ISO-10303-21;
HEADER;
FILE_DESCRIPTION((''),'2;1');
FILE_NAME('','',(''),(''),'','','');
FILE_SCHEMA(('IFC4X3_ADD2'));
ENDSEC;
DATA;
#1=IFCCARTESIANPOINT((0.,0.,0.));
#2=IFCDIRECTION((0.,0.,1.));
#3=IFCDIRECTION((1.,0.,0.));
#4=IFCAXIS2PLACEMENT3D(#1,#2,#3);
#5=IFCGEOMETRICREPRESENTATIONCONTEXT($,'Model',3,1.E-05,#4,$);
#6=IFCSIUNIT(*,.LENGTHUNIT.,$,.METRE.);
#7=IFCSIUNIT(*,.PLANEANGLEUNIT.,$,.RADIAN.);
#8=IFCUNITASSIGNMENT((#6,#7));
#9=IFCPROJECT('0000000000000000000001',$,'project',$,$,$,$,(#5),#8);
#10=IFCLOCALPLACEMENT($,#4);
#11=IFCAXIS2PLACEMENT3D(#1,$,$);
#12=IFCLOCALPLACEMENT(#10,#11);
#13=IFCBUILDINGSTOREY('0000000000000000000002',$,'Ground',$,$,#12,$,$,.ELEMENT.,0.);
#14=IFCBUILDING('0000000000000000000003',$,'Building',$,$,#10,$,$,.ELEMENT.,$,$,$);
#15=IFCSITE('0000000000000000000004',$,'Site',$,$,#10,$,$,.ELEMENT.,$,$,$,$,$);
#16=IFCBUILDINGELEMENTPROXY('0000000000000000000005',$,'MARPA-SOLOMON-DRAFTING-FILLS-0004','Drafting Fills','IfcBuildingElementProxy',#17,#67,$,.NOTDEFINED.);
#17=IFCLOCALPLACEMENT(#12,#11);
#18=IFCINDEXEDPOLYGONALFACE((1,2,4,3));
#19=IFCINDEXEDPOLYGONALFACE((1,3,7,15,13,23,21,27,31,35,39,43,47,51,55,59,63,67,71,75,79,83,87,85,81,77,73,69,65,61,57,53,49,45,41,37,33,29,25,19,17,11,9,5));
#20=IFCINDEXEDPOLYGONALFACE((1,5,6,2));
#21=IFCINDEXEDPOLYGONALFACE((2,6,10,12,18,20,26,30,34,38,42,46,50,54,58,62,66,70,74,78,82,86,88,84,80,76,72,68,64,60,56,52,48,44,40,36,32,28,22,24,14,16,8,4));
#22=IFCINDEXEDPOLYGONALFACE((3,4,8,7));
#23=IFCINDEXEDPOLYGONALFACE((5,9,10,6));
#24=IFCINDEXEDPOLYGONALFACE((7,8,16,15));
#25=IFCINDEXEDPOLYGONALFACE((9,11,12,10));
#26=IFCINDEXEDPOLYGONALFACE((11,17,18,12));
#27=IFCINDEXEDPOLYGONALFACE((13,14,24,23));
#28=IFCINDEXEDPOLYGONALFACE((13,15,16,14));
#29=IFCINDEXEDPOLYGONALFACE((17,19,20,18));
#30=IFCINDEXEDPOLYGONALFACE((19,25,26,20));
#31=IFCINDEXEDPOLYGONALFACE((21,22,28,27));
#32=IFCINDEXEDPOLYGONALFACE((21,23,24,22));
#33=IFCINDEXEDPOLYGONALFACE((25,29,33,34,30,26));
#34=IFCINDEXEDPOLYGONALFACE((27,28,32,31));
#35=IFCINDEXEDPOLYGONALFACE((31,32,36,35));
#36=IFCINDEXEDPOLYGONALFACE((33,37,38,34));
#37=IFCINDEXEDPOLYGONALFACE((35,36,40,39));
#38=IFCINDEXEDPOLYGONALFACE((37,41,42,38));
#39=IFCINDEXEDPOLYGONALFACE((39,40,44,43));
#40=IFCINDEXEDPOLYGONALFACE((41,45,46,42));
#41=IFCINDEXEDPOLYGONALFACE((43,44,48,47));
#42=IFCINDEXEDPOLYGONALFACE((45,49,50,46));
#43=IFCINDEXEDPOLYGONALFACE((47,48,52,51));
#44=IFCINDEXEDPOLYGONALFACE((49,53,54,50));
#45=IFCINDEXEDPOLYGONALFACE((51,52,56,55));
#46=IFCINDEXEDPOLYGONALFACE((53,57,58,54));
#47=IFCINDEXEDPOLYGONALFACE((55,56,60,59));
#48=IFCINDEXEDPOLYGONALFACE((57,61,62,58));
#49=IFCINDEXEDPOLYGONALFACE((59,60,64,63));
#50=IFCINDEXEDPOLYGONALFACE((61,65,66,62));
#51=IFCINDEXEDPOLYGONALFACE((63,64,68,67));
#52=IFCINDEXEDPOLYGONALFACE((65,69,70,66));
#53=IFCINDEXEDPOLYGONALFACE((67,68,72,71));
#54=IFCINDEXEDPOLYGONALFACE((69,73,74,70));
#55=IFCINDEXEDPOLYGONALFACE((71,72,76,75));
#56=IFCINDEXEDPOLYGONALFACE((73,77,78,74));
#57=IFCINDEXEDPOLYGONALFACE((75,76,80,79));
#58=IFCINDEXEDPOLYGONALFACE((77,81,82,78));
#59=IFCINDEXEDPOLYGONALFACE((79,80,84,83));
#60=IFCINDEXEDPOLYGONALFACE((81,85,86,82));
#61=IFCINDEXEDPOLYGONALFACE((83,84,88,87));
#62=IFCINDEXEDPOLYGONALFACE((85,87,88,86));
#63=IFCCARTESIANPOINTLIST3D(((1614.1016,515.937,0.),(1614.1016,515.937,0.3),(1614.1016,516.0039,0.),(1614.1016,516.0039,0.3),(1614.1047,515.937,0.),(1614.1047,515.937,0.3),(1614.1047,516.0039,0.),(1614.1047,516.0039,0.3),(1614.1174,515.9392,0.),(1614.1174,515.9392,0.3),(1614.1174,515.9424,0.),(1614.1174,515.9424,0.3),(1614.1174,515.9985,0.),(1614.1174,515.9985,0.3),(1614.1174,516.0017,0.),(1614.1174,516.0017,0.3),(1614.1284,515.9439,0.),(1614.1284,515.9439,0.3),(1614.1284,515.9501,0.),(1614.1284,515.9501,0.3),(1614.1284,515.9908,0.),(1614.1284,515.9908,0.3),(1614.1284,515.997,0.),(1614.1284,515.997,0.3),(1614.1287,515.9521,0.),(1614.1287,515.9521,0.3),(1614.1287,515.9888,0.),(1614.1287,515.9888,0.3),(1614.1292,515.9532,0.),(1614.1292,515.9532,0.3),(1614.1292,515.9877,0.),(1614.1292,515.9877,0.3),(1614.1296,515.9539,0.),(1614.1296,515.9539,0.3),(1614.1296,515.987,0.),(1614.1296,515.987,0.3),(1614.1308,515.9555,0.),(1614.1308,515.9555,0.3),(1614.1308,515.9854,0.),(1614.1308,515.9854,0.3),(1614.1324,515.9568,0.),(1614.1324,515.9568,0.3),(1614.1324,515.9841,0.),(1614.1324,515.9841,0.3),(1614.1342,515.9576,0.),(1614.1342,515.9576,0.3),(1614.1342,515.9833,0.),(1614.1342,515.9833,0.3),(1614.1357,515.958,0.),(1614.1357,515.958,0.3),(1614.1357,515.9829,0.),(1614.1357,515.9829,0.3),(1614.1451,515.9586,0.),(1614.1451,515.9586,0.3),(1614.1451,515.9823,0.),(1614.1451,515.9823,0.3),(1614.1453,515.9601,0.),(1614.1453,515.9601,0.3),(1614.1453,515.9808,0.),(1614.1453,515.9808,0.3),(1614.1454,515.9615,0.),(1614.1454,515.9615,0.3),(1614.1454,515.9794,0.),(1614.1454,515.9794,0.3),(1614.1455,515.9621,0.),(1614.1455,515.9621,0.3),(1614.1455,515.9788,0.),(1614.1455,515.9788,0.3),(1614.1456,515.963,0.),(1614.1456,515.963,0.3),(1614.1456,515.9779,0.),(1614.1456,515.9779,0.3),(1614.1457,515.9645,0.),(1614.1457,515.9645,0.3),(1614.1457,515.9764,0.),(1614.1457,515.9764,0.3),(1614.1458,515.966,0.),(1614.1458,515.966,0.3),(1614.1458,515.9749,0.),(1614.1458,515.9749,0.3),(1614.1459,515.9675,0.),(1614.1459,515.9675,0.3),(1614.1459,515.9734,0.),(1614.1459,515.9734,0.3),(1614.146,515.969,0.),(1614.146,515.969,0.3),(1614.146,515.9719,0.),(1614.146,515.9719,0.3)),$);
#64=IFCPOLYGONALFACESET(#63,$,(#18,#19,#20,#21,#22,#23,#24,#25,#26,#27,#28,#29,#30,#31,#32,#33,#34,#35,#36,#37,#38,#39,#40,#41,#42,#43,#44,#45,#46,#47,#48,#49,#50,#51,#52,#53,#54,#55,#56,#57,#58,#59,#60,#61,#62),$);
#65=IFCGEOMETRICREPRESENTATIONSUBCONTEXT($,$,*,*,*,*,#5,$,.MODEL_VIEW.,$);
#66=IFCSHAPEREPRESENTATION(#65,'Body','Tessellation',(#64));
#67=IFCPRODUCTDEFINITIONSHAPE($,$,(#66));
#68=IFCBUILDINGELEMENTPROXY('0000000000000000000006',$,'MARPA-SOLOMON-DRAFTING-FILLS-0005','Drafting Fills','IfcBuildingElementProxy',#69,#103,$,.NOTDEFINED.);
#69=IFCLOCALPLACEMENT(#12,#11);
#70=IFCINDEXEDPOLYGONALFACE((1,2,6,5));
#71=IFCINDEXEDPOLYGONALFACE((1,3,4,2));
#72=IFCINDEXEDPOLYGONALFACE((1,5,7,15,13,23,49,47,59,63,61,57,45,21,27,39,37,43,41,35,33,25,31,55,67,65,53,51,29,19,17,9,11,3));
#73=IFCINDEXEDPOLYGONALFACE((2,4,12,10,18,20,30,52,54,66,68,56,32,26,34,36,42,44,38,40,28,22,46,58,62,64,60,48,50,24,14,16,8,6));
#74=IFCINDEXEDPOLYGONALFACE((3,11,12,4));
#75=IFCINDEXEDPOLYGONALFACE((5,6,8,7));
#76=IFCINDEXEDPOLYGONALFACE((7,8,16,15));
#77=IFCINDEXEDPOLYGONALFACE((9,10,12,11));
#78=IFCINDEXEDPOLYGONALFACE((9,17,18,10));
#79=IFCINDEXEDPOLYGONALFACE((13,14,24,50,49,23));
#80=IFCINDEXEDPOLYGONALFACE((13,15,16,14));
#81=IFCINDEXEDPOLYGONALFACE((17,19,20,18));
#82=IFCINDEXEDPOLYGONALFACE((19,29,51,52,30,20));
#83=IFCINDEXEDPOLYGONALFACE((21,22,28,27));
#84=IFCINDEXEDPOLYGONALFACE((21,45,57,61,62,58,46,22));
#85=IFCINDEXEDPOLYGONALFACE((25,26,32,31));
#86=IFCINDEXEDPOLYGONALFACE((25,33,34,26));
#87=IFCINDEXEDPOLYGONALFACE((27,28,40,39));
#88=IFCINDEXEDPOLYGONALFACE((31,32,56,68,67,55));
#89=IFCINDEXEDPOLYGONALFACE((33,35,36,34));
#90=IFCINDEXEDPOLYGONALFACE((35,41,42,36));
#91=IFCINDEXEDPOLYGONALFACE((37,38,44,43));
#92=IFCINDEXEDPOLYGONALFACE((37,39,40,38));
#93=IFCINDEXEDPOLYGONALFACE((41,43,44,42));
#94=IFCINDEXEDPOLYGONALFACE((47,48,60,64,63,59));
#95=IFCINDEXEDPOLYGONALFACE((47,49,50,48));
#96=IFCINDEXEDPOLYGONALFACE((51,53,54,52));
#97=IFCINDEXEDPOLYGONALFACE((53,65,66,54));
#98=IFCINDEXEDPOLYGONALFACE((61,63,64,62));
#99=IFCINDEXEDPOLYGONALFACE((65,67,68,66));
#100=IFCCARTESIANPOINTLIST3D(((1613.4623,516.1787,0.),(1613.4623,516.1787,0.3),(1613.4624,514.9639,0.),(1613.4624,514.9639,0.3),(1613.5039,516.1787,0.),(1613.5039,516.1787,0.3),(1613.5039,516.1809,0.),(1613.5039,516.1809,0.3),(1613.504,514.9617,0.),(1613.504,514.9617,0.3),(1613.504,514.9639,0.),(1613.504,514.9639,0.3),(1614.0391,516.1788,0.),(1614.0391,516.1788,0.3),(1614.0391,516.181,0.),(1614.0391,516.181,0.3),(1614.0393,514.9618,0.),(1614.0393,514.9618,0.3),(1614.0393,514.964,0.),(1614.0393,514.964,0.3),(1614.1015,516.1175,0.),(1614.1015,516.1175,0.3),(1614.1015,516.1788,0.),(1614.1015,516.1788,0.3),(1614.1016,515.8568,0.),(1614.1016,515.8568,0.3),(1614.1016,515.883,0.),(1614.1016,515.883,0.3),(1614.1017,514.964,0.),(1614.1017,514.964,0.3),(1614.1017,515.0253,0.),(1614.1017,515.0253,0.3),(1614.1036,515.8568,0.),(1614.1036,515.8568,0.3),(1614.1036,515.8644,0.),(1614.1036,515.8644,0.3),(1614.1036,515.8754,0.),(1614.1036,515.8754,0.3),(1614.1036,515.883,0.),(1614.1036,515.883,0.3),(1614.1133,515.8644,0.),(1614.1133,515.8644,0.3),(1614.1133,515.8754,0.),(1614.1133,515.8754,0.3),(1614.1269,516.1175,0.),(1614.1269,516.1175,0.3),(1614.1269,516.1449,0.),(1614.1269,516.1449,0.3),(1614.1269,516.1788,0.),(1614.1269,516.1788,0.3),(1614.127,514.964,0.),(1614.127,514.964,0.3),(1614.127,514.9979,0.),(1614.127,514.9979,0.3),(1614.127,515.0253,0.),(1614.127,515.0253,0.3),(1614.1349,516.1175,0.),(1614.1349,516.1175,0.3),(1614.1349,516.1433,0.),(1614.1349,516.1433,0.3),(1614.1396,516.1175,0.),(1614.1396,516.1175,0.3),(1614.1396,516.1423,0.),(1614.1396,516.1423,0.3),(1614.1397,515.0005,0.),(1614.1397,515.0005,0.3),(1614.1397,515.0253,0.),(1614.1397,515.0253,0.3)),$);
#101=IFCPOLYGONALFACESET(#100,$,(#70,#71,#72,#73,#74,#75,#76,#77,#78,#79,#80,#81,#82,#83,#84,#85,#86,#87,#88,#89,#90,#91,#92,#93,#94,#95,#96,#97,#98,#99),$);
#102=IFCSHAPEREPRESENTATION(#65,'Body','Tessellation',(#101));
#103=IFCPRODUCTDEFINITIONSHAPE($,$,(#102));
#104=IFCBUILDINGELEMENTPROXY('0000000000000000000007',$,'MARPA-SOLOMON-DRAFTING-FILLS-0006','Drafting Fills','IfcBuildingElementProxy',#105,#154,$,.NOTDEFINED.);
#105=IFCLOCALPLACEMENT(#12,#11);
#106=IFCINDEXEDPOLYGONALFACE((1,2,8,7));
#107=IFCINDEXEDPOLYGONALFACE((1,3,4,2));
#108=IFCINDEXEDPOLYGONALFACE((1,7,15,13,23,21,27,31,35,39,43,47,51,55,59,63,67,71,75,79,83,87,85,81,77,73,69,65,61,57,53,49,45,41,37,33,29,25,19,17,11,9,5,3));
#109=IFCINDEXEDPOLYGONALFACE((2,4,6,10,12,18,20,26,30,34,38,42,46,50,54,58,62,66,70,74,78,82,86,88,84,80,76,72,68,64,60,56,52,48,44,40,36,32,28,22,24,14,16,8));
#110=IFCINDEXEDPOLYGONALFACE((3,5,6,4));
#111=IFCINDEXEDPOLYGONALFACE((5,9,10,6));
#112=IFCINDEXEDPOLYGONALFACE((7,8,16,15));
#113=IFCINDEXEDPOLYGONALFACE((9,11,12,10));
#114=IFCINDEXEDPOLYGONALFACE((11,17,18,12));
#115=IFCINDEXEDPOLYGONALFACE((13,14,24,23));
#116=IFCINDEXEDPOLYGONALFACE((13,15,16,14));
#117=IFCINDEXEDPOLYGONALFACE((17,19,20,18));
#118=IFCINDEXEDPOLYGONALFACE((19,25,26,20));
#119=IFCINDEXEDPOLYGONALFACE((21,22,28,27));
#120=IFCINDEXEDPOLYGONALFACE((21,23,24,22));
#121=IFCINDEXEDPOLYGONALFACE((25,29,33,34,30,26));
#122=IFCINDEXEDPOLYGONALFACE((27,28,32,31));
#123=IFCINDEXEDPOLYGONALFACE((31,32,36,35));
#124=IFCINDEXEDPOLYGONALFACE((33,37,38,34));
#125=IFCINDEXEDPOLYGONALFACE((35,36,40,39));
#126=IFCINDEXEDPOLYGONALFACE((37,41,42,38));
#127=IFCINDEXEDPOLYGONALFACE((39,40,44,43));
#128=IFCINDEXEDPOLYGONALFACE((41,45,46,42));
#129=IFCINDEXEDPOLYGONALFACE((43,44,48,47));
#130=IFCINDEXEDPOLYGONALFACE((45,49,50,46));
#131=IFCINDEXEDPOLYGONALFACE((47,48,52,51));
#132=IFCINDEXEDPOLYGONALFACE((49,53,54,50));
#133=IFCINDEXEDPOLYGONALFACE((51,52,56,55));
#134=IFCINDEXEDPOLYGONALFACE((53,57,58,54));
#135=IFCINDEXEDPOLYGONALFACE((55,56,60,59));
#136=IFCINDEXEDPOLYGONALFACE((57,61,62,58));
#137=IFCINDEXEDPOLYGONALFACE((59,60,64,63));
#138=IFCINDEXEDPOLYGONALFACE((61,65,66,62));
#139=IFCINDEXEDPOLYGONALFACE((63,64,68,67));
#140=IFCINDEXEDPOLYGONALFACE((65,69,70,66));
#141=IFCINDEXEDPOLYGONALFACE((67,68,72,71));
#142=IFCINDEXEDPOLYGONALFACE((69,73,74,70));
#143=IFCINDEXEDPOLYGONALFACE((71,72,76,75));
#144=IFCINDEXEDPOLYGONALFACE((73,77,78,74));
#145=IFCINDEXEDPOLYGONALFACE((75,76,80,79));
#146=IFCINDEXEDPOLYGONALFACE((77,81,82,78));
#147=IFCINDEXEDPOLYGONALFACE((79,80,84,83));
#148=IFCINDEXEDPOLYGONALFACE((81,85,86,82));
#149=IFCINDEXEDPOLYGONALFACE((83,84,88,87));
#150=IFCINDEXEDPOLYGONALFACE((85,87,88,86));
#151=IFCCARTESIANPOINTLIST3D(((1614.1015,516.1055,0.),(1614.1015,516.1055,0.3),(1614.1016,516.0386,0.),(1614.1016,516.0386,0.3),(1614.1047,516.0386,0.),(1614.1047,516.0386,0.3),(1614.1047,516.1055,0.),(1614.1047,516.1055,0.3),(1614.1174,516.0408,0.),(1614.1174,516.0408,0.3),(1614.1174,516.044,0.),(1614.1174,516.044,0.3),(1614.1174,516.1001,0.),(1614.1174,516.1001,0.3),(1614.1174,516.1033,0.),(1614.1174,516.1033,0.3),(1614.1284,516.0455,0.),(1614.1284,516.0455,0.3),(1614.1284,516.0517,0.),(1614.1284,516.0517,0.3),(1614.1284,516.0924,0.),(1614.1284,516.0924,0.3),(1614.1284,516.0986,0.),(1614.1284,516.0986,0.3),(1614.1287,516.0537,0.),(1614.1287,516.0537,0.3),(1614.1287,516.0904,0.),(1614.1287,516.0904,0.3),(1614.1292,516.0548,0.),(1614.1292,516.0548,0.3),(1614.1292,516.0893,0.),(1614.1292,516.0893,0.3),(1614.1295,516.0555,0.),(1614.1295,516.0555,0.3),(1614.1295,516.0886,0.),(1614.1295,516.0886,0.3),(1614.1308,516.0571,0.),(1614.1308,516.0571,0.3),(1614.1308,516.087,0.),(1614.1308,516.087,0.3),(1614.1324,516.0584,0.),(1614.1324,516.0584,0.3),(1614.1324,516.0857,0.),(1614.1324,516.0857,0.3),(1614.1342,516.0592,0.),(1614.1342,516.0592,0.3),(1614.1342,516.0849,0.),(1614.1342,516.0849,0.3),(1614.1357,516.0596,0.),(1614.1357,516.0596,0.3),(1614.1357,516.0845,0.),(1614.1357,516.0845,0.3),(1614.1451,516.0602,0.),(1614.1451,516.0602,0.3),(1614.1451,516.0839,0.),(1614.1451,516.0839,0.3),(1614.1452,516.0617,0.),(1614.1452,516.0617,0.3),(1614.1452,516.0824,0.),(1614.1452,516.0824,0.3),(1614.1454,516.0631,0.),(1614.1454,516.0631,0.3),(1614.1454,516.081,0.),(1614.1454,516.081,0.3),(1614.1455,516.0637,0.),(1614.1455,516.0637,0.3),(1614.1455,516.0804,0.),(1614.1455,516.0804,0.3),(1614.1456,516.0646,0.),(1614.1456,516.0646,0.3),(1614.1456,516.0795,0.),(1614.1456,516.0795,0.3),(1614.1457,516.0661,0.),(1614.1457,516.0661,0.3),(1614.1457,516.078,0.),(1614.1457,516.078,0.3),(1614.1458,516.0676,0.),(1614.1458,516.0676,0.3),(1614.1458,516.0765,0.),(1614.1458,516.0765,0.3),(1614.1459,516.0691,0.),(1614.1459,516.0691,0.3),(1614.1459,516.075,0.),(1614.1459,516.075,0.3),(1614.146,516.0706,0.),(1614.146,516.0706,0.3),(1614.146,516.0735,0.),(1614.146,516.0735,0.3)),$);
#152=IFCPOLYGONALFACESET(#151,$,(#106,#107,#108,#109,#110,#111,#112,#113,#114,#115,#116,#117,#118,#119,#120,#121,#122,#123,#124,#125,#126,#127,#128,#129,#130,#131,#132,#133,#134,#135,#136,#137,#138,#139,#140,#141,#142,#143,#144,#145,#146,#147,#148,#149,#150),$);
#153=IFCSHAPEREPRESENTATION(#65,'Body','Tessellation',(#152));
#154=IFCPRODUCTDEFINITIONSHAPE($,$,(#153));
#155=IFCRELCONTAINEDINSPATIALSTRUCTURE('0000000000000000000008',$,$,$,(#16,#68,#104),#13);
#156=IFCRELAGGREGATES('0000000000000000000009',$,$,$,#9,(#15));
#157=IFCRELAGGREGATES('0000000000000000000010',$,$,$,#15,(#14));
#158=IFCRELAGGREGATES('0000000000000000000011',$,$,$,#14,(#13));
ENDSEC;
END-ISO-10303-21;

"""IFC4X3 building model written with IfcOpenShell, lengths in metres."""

from ifc_helpers import new_model, si_unit, frame, origin, origin_with_axes, place, context, subcontext, project, spatial, polyline, outline, extrude, element, save


model = new_model("IFC4X3")

# Units and contexts
model_context = context("Model", 3, precision=1e-05, world=origin_with_axes())
sub_context = subcontext(model_context, None, None, "MODEL_VIEW")
ifc_project = project(units=[si_unit("LENGTHUNIT", "METRE"), si_unit("PLANEANGLEUNIT", "RADIAN")], contexts=[model_context])

# Site, building, storey
placement = place(None, origin_with_axes())
site = spatial("IfcSite", under=ifc_project, at=placement, Name="Site", CompositionType="ELEMENT")
building = spatial("IfcBuilding", under=site, at=placement, Name="Building", CompositionType="ELEMENT")
storey_placement = place(placement, origin())
storey = spatial("IfcBuildingStorey", under=building, at=storey_placement, Name="Ground", CompositionType="ELEMENT", Elevation=0.0)

# Building element proxies
proxy_1_placement = place(placement, frame((1614.1016, 515.937, 0.0)))
element("IfcBuildingElementProxy", 1, at=proxy_1_placement, inside=storey, Name="MARPA-SOLOMON-DRAFTING-FILLS-0004", Description="Drafting Fills", ObjectType="IfcBuildingElementProxy", PredefinedType="NOTDEFINED", context=sub_context, shape_type="SweptSolid", body=[
    extrude(outline(polyline([(0.0159, 0.0022), (0.0159, 0.0054), (0.0268, 0.007), (0.0268, 0.0131), (0.0272, 0.0151), (0.0277, 0.0162), (0.028, 0.017), (0.0292, 0.0186), (0.0308, 0.0198), (0.0326, 0.0207), (0.0342, 0.021), (0.0435, 0.0216), (0.0437, 0.0231), (0.0439, 0.0246), (0.0439, 0.0251), (0.044, 0.0261), (0.0441, 0.0275), (0.0443, 0.029), (0.0443, 0.0305), (0.0445, 0.032), (0.0445, 0.035), (0.0443, 0.0365), (0.0442, 0.0379), (0.0441, 0.0394), (0.044, 0.0409), (0.0439, 0.0419), (0.0439, 0.0424), (0.0437, 0.0439), (0.0435, 0.0453), (0.0342, 0.046), (0.0326, 0.0463), (0.0308, 0.0471), (0.0292, 0.0484), (0.028, 0.05), (0.0277, 0.0507), (0.0272, 0.0519), (0.0268, 0.0538), (0.0268, 0.06), (0.0159, 0.0616), (0.0159, 0.0647), (0.0032, 0.067), (0.0, 0.067), (0.0, 0.0), (0.0032, 0.0), (0.0159, 0.0022)])), origin(), (0.0, 0.0, 1.0), 0.3),
])
proxy_2_placement = place(placement, frame((1613.4623, 514.9617, 0.0)))
element("IfcBuildingElementProxy", 2, at=proxy_2_placement, inside=storey, Name="MARPA-SOLOMON-DRAFTING-FILLS-0005", Description="Drafting Fills", ObjectType="IfcBuildingElementProxy", PredefinedType="NOTDEFINED", context=sub_context, shape_type="SweptSolid", body=[
    extrude(outline(polyline([(0.0417, 0.0022), (0.0417, 0.0), (0.577, 0.0001), (0.577, 0.0023), (0.6393, 0.0023), (0.6647, 0.0023), (0.6647, 0.0362), (0.6774, 0.0387), (0.6774, 0.0636), (0.6647, 0.0636), (0.6393, 0.0636), (0.6393, 0.8951), (0.6413, 0.8951), (0.6413, 0.9027), (0.651, 0.9027), (0.651, 0.9137), (0.6413, 0.9137), (0.6413, 0.9213), (0.6393, 0.9213), (0.6392, 1.1557), (0.6646, 1.1557), (0.6726, 1.1557), (0.6773, 1.1557), (0.6773, 1.1806), (0.6726, 1.1815), (0.6646, 1.1831), (0.6646, 1.2171), (0.6392, 1.2171), (0.5768, 1.217), (0.5768, 1.2193), (0.0416, 1.2192), (0.0416, 1.217), (0.0, 1.217), (0.0001, 0.0022), (0.0417, 0.0022)])), origin(), (0.0, 0.0, 1.0), 0.3),
])
proxy_3_placement = place(placement, frame((1614.1015, 516.0386, 0.0)))
element("IfcBuildingElementProxy", 3, at=proxy_3_placement, inside=storey, Name="MARPA-SOLOMON-DRAFTING-FILLS-0006", Description="Drafting Fills", ObjectType="IfcBuildingElementProxy", PredefinedType="NOTDEFINED", context=sub_context, shape_type="SweptSolid", body=[
    extrude(outline(polyline([(0.0159, 0.0022), (0.0159, 0.0054), (0.0268, 0.007), (0.0268, 0.0131), (0.0272, 0.0151), (0.0277, 0.0162), (0.028, 0.017), (0.0292, 0.0186), (0.0308, 0.0198), (0.0326, 0.0207), (0.0342, 0.021), (0.0435, 0.0216), (0.0437, 0.0231), (0.0439, 0.0246), (0.0439, 0.0251), (0.044, 0.0261), (0.0441, 0.0275), (0.0443, 0.029), (0.0443, 0.0305), (0.0445, 0.032), (0.0445, 0.035), (0.0443, 0.0365), (0.0442, 0.0379), (0.0441, 0.0394), (0.044, 0.0409), (0.0439, 0.0419), (0.0439, 0.0424), (0.0437, 0.0439), (0.0435, 0.0453), (0.0342, 0.046), (0.0326, 0.0463), (0.0308, 0.0471), (0.0292, 0.0484), (0.028, 0.05), (0.0277, 0.0507), (0.0272, 0.0519), (0.0268, 0.0538), (0.0268, 0.06), (0.0159, 0.0616), (0.0159, 0.0647), (0.0032, 0.067), (0.0, 0.067), (0.0, 0.0), (0.0032, 0.0), (0.0159, 0.0022)])), origin(), (0.0, 0.0, 1.0), 0.3),
])

save(model, "model.ifc")
